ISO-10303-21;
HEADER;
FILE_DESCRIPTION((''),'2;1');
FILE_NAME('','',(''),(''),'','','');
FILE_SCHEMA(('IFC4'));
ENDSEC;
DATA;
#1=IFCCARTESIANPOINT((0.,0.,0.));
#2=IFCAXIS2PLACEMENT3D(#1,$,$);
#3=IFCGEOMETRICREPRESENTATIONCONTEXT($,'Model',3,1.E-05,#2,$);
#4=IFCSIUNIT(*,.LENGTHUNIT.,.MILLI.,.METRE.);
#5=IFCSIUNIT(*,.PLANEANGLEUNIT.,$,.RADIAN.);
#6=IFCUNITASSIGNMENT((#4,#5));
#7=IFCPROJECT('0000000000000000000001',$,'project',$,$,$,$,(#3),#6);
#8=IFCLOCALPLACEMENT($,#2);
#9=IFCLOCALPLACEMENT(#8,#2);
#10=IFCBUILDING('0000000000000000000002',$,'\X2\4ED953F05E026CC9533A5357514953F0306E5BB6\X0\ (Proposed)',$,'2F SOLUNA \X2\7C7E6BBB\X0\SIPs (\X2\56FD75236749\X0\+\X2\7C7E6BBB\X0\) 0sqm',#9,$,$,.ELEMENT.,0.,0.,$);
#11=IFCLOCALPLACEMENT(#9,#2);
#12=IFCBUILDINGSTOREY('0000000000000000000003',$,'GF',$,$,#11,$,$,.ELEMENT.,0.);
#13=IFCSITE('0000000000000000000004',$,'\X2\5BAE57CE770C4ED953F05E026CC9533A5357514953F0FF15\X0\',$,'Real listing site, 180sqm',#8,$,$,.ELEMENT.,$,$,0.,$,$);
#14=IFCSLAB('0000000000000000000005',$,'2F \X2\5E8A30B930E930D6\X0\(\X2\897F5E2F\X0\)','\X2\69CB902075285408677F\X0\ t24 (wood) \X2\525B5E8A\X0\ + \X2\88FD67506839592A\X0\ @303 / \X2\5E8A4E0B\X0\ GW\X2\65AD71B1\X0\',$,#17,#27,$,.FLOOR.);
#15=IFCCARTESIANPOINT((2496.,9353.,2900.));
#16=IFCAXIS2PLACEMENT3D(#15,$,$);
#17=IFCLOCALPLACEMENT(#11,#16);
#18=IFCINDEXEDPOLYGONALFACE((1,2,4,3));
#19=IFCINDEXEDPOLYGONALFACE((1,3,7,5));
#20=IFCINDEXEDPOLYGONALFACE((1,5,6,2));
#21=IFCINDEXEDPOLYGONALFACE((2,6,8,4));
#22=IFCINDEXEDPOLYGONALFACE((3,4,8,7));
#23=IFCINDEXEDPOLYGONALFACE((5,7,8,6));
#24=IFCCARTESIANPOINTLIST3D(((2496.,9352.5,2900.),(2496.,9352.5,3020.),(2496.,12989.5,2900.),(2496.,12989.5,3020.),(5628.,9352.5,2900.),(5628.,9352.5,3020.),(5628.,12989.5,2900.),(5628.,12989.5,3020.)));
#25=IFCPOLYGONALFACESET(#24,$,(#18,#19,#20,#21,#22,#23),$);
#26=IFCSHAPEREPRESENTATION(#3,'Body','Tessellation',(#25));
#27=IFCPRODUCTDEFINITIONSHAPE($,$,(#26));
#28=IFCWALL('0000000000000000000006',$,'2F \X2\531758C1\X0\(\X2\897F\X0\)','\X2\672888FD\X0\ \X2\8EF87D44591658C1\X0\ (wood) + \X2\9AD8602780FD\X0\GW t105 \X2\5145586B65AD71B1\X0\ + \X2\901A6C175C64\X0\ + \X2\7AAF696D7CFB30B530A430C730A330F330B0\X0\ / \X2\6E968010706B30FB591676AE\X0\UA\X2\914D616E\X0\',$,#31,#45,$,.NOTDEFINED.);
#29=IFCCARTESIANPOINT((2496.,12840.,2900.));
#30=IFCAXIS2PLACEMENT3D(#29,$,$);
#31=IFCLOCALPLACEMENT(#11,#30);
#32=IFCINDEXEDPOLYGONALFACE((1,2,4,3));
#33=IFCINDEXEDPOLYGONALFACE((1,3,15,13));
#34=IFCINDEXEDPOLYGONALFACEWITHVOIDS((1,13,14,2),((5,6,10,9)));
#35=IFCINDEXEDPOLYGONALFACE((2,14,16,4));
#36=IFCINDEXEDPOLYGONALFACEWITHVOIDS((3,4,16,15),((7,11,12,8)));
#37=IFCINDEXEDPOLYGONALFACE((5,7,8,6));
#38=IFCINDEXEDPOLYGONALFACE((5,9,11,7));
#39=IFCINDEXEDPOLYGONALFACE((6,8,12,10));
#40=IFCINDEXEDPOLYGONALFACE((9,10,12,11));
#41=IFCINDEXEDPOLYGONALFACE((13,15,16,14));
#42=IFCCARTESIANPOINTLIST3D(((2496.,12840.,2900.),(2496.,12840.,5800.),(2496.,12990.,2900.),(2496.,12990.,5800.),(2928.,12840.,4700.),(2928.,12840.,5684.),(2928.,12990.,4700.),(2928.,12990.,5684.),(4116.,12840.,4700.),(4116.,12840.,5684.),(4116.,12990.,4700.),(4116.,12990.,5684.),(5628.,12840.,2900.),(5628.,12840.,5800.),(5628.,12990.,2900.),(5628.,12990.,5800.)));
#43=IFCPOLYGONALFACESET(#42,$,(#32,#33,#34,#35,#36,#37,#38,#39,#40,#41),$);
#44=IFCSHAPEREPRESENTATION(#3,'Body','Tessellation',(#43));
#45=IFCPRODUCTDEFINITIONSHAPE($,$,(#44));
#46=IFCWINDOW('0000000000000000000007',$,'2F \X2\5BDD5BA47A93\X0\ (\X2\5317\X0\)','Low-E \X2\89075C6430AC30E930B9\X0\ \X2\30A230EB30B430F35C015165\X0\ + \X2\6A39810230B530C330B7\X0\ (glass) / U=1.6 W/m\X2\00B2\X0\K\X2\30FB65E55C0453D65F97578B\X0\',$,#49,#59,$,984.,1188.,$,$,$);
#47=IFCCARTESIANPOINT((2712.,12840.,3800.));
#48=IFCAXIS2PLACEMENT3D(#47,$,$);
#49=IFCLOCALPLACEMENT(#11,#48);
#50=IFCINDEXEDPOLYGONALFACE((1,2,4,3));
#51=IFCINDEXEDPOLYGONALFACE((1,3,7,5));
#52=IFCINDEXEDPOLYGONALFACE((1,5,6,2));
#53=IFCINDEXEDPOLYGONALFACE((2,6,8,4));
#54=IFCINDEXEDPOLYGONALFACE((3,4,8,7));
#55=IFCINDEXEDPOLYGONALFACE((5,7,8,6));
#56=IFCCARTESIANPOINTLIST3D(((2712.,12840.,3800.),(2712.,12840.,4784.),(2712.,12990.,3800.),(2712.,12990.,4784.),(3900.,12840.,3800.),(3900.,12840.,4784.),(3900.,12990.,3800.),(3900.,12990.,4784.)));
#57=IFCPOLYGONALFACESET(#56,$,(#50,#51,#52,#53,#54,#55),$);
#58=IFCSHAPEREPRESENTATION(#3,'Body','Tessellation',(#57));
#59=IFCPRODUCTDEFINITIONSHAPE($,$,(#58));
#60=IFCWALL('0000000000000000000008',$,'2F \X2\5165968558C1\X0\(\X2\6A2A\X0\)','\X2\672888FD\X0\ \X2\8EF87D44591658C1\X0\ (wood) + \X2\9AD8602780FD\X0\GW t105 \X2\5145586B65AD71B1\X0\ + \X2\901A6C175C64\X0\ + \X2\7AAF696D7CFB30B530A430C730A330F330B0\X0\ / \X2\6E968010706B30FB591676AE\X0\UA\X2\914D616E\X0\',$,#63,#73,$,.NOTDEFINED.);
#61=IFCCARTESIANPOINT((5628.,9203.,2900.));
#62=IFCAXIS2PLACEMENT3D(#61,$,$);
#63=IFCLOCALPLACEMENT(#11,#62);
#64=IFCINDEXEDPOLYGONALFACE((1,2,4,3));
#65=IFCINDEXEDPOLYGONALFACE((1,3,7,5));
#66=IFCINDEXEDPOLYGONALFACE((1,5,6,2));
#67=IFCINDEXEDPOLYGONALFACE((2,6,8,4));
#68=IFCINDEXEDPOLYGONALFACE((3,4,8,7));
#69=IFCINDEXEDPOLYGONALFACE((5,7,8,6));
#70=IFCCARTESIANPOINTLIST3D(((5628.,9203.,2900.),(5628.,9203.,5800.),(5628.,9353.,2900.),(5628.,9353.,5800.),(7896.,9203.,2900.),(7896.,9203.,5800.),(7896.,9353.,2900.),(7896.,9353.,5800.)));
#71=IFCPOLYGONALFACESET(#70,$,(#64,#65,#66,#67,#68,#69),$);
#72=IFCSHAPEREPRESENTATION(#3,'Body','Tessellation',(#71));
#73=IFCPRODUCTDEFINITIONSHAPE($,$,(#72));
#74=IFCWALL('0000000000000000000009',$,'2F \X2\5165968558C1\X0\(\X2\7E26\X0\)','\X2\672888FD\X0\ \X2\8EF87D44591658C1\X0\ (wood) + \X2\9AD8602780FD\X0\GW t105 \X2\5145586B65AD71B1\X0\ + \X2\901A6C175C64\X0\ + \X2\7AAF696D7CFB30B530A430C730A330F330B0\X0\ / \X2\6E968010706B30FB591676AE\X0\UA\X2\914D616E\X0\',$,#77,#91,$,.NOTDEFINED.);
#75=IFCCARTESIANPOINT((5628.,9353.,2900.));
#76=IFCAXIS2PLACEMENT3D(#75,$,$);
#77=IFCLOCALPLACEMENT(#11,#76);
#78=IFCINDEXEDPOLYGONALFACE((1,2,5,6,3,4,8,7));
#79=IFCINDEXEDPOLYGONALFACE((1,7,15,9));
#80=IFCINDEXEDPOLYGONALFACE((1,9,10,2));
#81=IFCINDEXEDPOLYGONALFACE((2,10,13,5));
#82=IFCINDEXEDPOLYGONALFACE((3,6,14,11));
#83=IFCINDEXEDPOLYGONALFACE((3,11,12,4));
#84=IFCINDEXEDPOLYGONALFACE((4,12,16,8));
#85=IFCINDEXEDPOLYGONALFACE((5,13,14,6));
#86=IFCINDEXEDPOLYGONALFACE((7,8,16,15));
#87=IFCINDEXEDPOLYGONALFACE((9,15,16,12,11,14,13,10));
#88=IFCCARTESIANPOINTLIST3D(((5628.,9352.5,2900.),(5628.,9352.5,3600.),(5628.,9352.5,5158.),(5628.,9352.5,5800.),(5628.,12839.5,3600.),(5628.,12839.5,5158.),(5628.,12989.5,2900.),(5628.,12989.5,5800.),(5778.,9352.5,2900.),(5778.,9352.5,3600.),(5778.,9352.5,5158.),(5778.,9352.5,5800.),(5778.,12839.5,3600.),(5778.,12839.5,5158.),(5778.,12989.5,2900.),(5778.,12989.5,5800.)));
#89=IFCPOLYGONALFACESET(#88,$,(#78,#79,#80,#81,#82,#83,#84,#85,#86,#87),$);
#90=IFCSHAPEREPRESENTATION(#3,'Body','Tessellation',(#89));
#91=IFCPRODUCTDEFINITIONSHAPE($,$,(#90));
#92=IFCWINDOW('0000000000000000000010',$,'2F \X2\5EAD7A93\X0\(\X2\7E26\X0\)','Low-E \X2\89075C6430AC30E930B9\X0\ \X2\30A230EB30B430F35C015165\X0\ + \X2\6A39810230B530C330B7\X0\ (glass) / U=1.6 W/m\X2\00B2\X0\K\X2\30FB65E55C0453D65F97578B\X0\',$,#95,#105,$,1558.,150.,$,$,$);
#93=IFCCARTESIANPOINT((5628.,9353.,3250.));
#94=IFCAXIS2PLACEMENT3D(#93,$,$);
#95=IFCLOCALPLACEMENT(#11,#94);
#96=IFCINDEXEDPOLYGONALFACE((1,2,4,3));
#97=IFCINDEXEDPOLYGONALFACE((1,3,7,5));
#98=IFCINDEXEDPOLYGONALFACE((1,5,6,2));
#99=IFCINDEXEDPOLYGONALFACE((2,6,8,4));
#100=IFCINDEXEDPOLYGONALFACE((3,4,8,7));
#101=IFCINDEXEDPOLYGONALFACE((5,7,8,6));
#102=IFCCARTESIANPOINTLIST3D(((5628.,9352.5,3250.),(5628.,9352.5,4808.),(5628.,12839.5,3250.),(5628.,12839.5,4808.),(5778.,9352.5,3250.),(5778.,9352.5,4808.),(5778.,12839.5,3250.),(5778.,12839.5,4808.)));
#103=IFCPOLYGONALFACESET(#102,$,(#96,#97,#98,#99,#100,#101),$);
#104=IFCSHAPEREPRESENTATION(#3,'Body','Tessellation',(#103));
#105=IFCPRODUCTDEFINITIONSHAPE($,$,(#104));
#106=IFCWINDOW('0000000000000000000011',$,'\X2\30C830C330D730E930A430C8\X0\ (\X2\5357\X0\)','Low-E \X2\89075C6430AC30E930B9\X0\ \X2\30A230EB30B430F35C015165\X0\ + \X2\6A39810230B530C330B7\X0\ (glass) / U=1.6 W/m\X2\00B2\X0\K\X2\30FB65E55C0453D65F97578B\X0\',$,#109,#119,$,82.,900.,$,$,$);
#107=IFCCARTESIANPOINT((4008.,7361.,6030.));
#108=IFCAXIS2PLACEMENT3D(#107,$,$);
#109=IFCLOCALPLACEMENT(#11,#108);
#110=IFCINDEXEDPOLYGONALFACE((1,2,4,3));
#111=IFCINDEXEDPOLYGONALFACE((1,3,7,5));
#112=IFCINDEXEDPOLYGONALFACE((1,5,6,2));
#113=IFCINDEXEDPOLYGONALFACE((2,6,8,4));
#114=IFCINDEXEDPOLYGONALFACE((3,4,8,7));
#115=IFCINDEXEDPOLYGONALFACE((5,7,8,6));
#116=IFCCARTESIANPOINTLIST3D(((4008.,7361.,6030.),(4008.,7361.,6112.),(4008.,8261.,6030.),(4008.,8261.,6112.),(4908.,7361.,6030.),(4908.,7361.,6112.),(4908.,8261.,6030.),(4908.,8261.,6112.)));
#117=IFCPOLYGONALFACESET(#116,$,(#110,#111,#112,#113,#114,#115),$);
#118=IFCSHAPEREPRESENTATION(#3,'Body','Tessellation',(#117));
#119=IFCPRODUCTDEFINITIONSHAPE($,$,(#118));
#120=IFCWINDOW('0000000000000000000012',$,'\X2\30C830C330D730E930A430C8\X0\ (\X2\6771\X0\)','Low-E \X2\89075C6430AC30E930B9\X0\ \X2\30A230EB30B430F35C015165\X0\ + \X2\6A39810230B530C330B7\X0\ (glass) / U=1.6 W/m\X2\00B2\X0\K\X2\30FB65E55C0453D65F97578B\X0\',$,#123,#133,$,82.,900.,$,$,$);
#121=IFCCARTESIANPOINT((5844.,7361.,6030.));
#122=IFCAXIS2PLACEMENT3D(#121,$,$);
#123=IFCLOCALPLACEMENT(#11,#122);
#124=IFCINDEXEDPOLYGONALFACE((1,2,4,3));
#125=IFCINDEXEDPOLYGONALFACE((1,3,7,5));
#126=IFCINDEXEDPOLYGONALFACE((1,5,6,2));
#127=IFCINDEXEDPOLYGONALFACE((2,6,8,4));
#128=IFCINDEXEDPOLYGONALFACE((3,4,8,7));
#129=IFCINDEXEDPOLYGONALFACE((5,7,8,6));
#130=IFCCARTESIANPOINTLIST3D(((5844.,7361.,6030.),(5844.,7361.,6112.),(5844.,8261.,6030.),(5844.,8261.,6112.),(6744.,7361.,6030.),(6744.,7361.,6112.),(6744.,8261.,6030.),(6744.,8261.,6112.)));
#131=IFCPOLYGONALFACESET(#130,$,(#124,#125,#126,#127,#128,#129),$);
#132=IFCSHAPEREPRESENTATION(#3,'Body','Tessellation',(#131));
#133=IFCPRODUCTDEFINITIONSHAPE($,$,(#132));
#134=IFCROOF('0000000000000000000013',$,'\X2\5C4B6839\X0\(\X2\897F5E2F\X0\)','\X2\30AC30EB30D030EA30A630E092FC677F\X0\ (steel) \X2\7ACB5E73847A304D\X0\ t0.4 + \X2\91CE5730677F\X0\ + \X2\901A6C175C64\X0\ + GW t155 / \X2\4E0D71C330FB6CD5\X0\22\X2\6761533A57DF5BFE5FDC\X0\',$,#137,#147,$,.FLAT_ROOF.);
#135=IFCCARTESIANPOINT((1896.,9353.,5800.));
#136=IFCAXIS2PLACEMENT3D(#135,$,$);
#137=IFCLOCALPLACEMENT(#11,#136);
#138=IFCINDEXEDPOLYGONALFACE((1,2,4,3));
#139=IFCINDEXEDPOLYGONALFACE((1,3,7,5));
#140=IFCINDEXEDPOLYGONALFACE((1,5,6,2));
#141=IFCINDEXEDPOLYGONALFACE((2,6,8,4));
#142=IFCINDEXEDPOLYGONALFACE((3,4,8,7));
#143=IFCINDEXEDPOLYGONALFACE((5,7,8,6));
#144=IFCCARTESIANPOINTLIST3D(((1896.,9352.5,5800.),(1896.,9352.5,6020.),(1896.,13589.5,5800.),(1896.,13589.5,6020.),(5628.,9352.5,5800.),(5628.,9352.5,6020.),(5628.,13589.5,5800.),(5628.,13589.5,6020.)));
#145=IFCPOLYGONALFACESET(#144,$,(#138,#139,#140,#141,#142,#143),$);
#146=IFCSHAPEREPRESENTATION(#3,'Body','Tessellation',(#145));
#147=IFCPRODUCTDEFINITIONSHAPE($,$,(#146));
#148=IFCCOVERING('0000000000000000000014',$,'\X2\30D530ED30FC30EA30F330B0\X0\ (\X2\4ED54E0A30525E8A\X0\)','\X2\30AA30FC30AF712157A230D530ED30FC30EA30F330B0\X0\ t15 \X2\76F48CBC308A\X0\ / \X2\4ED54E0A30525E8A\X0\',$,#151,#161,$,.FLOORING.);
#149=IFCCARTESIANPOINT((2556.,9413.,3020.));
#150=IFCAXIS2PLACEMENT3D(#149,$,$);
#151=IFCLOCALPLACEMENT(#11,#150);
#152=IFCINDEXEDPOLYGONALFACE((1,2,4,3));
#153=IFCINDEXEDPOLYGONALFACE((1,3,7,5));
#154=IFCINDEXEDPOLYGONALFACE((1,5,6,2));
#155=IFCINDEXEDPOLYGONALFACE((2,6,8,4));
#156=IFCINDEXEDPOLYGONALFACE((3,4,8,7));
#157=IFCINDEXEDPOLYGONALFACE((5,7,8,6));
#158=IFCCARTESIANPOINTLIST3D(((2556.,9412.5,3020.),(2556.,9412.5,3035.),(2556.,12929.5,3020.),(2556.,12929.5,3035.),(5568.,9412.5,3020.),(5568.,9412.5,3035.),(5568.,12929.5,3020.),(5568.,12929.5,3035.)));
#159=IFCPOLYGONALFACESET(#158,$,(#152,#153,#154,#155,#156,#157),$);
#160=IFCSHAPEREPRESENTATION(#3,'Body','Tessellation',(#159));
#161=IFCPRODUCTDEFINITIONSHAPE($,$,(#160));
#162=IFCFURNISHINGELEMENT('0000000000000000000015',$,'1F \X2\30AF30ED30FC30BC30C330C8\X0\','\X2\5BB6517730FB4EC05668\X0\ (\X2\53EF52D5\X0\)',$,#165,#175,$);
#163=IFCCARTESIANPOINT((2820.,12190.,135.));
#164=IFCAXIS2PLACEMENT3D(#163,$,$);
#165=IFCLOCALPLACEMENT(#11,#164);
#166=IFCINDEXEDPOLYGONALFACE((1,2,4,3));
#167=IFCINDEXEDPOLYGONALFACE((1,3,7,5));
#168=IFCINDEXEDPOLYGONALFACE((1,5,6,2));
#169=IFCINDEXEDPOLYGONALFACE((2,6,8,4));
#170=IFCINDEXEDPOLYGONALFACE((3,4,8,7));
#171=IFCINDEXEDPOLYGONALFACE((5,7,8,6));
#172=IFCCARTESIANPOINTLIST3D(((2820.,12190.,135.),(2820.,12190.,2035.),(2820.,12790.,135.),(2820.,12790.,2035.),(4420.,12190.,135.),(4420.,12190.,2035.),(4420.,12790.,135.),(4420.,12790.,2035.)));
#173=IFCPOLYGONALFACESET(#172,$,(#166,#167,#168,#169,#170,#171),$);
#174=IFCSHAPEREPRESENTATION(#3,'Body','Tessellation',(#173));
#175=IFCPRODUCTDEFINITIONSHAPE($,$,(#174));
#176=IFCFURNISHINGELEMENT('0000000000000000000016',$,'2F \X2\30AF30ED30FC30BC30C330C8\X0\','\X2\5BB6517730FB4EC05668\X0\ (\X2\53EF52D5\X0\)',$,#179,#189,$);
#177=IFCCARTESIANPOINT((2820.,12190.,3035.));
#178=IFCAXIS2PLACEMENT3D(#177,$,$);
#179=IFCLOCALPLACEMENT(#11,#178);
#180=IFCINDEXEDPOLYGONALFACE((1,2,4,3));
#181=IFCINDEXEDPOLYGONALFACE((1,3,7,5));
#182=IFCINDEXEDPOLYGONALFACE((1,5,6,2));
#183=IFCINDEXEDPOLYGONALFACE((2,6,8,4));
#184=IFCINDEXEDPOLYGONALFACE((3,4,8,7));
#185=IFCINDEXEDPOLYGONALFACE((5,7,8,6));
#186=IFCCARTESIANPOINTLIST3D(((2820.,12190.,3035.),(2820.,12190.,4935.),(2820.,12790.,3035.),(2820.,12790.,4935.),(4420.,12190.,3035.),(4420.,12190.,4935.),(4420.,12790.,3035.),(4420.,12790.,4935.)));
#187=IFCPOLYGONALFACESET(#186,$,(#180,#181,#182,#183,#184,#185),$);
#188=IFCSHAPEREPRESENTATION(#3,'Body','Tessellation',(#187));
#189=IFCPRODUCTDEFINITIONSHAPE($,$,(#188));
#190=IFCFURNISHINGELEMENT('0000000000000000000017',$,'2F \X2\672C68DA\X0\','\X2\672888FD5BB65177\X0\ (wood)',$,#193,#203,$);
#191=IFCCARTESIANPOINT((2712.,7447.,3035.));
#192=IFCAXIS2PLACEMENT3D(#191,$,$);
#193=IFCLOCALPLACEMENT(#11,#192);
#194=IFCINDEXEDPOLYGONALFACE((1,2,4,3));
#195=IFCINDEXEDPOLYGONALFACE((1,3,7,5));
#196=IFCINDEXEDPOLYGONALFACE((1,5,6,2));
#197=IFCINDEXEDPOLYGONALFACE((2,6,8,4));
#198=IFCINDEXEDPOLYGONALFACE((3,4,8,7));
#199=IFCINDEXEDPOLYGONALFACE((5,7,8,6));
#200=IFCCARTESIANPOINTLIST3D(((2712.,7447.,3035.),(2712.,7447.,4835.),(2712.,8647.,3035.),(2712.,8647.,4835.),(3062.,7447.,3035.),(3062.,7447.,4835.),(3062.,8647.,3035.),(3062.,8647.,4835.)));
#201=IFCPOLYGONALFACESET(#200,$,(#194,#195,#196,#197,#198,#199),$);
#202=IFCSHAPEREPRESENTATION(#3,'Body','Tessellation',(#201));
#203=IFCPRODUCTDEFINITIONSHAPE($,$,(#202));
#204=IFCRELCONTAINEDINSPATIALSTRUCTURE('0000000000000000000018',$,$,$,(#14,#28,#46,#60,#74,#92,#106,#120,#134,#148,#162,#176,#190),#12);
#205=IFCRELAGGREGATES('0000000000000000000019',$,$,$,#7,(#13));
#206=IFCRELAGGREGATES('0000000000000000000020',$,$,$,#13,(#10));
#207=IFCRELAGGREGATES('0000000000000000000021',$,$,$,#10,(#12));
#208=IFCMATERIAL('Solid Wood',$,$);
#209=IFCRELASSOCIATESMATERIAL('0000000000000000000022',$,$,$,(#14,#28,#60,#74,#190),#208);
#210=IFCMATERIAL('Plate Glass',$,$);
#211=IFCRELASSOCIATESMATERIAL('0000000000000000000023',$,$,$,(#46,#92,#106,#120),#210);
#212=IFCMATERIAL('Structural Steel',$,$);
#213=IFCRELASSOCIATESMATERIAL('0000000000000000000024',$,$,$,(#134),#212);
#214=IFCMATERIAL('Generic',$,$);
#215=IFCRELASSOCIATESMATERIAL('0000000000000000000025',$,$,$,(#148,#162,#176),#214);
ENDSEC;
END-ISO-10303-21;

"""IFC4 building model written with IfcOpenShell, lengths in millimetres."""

from ifc_helpers import new_model, si_unit, frame, frame_2d, origin, place, context, project, spatial, rectangle, extrude, material, element, fill, save


model = new_model("IFC4")

# Units and contexts
model_context = context("Model", 3, precision=1e-05, world=origin())
ifc_project = project(units=[si_unit("LENGTHUNIT", "METRE", prefix="MILLI"), si_unit("PLANEANGLEUNIT", "RADIAN")], contexts=[model_context])

# Site, building, storey
site_placement = place(None, origin())
site = spatial("IfcSite", under=ifc_project, at=site_placement, Name="宮城県仙台市泉区南光台５", ObjectType="Real listing site, 180sqm", CompositionType="ELEMENT", RefElevation=0.0)
building_placement = place(site_placement, origin())
building = spatial("IfcBuilding", under=site, at=building_placement, Name="仙台市泉区南光台の家 (Proposed)", ObjectType="2F SOLUNA 籾殻SIPs (国産杉+籾殻) 0sqm", CompositionType="ELEMENT", ElevationOfRefHeight=0.0, ElevationOfTerrain=0.0)
storey_placement = place(building_placement, origin())
storey = spatial("IfcBuildingStorey", under=building, at=storey_placement, Name="GF", CompositionType="ELEMENT", Elevation=0.0)

# Slab
ifc_material_1 = material(Name="Solid Wood")
slab_placement = place(storey_placement, frame((2496.0, 9353.0, 2900.0)))
element("IfcSlab", 1, at=slab_placement, inside=storey, material=ifc_material_1, Name="2F 床スラブ(西帯)", Description="構造用合板 t24 (wood) 剛床 + 製材根太 @303 / 床下 GW断熱", PredefinedType="FLOOR", context=model_context, shape_type="SweptSolid", body=[
    extrude(rectangle(XDim=3132.0, YDim=3637.0, at=frame_2d((1566.0, 1818.0))), frame((2496.0, 9353.0, 2900.0)), (0.0, 0.0, 1.0), 120.0),
])

# Wall, opening, window
wall_1_placement = place(storey_placement, frame((2496.0, 12840.0, 2900.0)))
wall_1 = element("IfcWall", 2, at=wall_1_placement, inside=storey, material=ifc_material_1, Name="2F 北壁(西)", Description="木製 軸組外壁 (wood) + 高性能GW t105 充填断熱 + 通気層 + 窯業系サイディング / 準耐火・外皮UA配慮", PredefinedType="NOTDEFINED", context=model_context, shape_type="SweptSolid", body=[
    extrude(rectangle(XDim=3132.0, YDim=150.0, at=frame_2d((1566.0, 75.0))), frame((2496.0, 12840.0, 2900.0)), (0.0, 0.0, 1.0), 2900.0),
])
opening_1_placement = place(storey_placement, frame((2712.0, 12840.0, 3800.0)))
opening_1 = element("IfcOpeningElement", 3, at=opening_1_placement, cuts=wall_1, PredefinedType="NOTDEFINED", context=model_context, shape_type="SweptSolid", body=[
    extrude(rectangle(XDim=1188.0, YDim=150.0, at=frame_2d((594.0, 75.0))), frame((2712.0, 12840.0, 3800.0)), (0.0, 0.0, 1.0), 984.0),
])
ifc_material_2 = material(Name="Plate Glass")
window_1_placement = place(storey_placement, frame((2712.0, 12840.0, 3800.0)))
window_1 = element("IfcWindow", 4, at=window_1_placement, inside=storey, material=ifc_material_2, Name="2F 寝室窓 (北)", Description="Low-E 複層ガラス アルゴン封入 + 樹脂サッシ (glass) / U=1.6 W/m²K・日射取得型", OverallHeight=984.0, OverallWidth=1188.0, context=model_context, shape_type="SweptSolid", body=[
    extrude(rectangle(XDim=1188.0, YDim=150.0, at=frame_2d((594.0, 75.0))), frame((2712.0, 12840.0, 3800.0)), (0.0, 0.0, 1.0), 984.0),
])
fill(opening_1, window_1)

# Wall
wall_2_placement = place(storey_placement, frame((5628.0, 9203.0, 2900.0)))
element("IfcWall", 5, at=wall_2_placement, inside=storey, material=ifc_material_1, Name="2F 入隅壁(横)", Description="木製 軸組外壁 (wood) + 高性能GW t105 充填断熱 + 通気層 + 窯業系サイディング / 準耐火・外皮UA配慮", PredefinedType="NOTDEFINED", context=model_context, shape_type="SweptSolid", body=[
    extrude(rectangle(XDim=2268.0, YDim=150.0, at=frame_2d((1134.0, 75.0))), frame((5628.0, 9203.0, 2900.0)), (0.0, 0.0, 1.0), 2900.0),
])

# Wall, opening, window
wall_3_placement = place(storey_placement, frame((5628.0, 9353.0, 2900.0)))
wall_3 = element("IfcWall", 6, at=wall_3_placement, inside=storey, material=ifc_material_1, Name="2F 入隅壁(縦)", Description="木製 軸組外壁 (wood) + 高性能GW t105 充填断熱 + 通気層 + 窯業系サイディング / 準耐火・外皮UA配慮", PredefinedType="NOTDEFINED", context=model_context, shape_type="SweptSolid", body=[
    extrude(rectangle(XDim=150.0, YDim=3637.0, at=frame_2d((75.0, 1818.0))), frame((5628.0, 9353.0, 2900.0)), (0.0, 0.0, 1.0), 2900.0),
])
opening_2_placement = place(storey_placement, frame((5628.0, 9353.0, 3250.0)))
opening_2 = element("IfcOpeningElement", 7, at=opening_2_placement, cuts=wall_3, PredefinedType="NOTDEFINED", context=model_context, shape_type="SweptSolid", body=[
    extrude(rectangle(XDim=150.0, YDim=3487.0, at=frame_2d((75.0, 1743.0))), frame((5628.0, 9353.0, 3250.0)), (0.0, 0.0, 1.0), 1558.0),
])
window_2_placement = place(storey_placement, frame((5628.0, 9353.0, 3250.0)))
window_2 = element("IfcWindow", 8, at=window_2_placement, inside=storey, material=ifc_material_2, Name="2F 庭窓(縦)", Description="Low-E 複層ガラス アルゴン封入 + 樹脂サッシ (glass) / U=1.6 W/m²K・日射取得型", OverallHeight=1558.0, OverallWidth=150.0, context=model_context, shape_type="SweptSolid", body=[
    extrude(rectangle(XDim=150.0, YDim=3487.0, at=frame_2d((75.0, 1743.0))), frame((5628.0, 9353.0, 3250.0)), (0.0, 0.0, 1.0), 1558.0),
])
fill(opening_2, window_2)

# Windows
window_3_placement = place(storey_placement, frame((4008.0, 7361.0, 6030.0)))
element("IfcWindow", 9, at=window_3_placement, inside=storey, material=ifc_material_2, Name="トップライト (南)", Description="Low-E 複層ガラス アルゴン封入 + 樹脂サッシ (glass) / U=1.6 W/m²K・日射取得型", OverallHeight=82.0, OverallWidth=900.0, context=model_context, shape_type="SweptSolid", body=[
    extrude(rectangle(XDim=900.0, YDim=900.0, at=frame_2d((450.0, 450.0))), frame((4008.0, 7361.0, 6030.0)), (0.0, 0.0, 1.0), 82.0),
])
window_4_placement = place(storey_placement, frame((5844.0, 7361.0, 6030.0)))
element("IfcWindow", 10, at=window_4_placement, inside=storey, material=ifc_material_2, Name="トップライト (東)", Description="Low-E 複層ガラス アルゴン封入 + 樹脂サッシ (glass) / U=1.6 W/m²K・日射取得型", OverallHeight=82.0, OverallWidth=900.0, context=model_context, shape_type="SweptSolid", body=[
    extrude(rectangle(XDim=900.0, YDim=900.0, at=frame_2d((450.0, 450.0))), frame((5844.0, 7361.0, 6030.0)), (0.0, 0.0, 1.0), 82.0),
])

# Roof
ifc_material_3 = material(Name="Structural Steel")
for number, where, name in (
    (11, (1896.0, 9353.0, 5800.0), "屋根(西帯)"),
):
    element("IfcRoof", number, at=place(storey_placement, frame(where)), inside=storey, material=ifc_material_3, Name=name, Description="ガルバリウム鋼板 (steel) 立平葺き t0.4 + 野地板 + 通気層 + GW t155 / 不燃・法22条区域対応", PredefinedType="FLAT_ROOF", context=model_context, shape_type="SweptSolid", body=[
        extrude(rectangle(XDim=3732.0, YDim=4237.0, at=frame_2d((1866.0, 2118.0))), frame((1896.0, 9353.0, 5800.0)), (0.0, 0.0, 1.0), 220.0),
    ])

# Covering
ifc_material_4 = material(Name="Generic")
covering_placement = place(storey_placement, frame((2556.0, 9413.0, 3020.0)))
element("IfcCovering", 12, at=covering_placement, inside=storey, material=ifc_material_4, Name="フローリング (仕上げ床)", Description="オーク無垢フローリング t15 直貼り / 仕上げ床", PredefinedType="FLOORING", context=model_context, shape_type="SweptSolid", body=[
    extrude(rectangle(XDim=3012.0, YDim=3517.0, at=frame_2d((1506.0, 1758.0))), frame((2556.0, 9413.0, 3020.0)), (0.0, 0.0, 1.0), 15.0),
])

# Furnishing elements
furnishing_1_placement = place(storey_placement, frame((2820.0, 12190.0, 135.0)))
element("IfcFurnishingElement", 13, at=furnishing_1_placement, inside=storey, material=ifc_material_4, Name="1F クローゼット", Description="家具・什器 (可動)", context=model_context, shape_type="SweptSolid", body=[
    extrude(rectangle(XDim=1600.0, YDim=600.0, at=frame_2d((800.0, 300.0))), frame((2820.0, 12190.0, 135.0)), (0.0, 0.0, 1.0), 1900.0),
])
furnishing_2_placement = place(storey_placement, frame((2820.0, 12190.0, 3035.0)))
element("IfcFurnishingElement", 14, at=furnishing_2_placement, inside=storey, material=ifc_material_4, Name="2F クローゼット", Description="家具・什器 (可動)", context=model_context, shape_type="SweptSolid", body=[
    extrude(rectangle(XDim=1600.0, YDim=600.0, at=frame_2d((800.0, 300.0))), frame((2820.0, 12190.0, 3035.0)), (0.0, 0.0, 1.0), 1900.0),
])
furnishing_3_placement = place(storey_placement, frame((2712.0, 7447.0, 3035.0)))
element("IfcFurnishingElement", 15, at=furnishing_3_placement, inside=storey, material=ifc_material_1, Name="2F 本棚", Description="木製家具 (wood)", context=model_context, shape_type="SweptSolid", body=[
    extrude(rectangle(XDim=350.0, YDim=1200.0, at=frame_2d((175.0, 600.0))), frame((2712.0, 7447.0, 3035.0)), (0.0, 0.0, 1.0), 1800.0),
])

save(model, "model.ifc")
